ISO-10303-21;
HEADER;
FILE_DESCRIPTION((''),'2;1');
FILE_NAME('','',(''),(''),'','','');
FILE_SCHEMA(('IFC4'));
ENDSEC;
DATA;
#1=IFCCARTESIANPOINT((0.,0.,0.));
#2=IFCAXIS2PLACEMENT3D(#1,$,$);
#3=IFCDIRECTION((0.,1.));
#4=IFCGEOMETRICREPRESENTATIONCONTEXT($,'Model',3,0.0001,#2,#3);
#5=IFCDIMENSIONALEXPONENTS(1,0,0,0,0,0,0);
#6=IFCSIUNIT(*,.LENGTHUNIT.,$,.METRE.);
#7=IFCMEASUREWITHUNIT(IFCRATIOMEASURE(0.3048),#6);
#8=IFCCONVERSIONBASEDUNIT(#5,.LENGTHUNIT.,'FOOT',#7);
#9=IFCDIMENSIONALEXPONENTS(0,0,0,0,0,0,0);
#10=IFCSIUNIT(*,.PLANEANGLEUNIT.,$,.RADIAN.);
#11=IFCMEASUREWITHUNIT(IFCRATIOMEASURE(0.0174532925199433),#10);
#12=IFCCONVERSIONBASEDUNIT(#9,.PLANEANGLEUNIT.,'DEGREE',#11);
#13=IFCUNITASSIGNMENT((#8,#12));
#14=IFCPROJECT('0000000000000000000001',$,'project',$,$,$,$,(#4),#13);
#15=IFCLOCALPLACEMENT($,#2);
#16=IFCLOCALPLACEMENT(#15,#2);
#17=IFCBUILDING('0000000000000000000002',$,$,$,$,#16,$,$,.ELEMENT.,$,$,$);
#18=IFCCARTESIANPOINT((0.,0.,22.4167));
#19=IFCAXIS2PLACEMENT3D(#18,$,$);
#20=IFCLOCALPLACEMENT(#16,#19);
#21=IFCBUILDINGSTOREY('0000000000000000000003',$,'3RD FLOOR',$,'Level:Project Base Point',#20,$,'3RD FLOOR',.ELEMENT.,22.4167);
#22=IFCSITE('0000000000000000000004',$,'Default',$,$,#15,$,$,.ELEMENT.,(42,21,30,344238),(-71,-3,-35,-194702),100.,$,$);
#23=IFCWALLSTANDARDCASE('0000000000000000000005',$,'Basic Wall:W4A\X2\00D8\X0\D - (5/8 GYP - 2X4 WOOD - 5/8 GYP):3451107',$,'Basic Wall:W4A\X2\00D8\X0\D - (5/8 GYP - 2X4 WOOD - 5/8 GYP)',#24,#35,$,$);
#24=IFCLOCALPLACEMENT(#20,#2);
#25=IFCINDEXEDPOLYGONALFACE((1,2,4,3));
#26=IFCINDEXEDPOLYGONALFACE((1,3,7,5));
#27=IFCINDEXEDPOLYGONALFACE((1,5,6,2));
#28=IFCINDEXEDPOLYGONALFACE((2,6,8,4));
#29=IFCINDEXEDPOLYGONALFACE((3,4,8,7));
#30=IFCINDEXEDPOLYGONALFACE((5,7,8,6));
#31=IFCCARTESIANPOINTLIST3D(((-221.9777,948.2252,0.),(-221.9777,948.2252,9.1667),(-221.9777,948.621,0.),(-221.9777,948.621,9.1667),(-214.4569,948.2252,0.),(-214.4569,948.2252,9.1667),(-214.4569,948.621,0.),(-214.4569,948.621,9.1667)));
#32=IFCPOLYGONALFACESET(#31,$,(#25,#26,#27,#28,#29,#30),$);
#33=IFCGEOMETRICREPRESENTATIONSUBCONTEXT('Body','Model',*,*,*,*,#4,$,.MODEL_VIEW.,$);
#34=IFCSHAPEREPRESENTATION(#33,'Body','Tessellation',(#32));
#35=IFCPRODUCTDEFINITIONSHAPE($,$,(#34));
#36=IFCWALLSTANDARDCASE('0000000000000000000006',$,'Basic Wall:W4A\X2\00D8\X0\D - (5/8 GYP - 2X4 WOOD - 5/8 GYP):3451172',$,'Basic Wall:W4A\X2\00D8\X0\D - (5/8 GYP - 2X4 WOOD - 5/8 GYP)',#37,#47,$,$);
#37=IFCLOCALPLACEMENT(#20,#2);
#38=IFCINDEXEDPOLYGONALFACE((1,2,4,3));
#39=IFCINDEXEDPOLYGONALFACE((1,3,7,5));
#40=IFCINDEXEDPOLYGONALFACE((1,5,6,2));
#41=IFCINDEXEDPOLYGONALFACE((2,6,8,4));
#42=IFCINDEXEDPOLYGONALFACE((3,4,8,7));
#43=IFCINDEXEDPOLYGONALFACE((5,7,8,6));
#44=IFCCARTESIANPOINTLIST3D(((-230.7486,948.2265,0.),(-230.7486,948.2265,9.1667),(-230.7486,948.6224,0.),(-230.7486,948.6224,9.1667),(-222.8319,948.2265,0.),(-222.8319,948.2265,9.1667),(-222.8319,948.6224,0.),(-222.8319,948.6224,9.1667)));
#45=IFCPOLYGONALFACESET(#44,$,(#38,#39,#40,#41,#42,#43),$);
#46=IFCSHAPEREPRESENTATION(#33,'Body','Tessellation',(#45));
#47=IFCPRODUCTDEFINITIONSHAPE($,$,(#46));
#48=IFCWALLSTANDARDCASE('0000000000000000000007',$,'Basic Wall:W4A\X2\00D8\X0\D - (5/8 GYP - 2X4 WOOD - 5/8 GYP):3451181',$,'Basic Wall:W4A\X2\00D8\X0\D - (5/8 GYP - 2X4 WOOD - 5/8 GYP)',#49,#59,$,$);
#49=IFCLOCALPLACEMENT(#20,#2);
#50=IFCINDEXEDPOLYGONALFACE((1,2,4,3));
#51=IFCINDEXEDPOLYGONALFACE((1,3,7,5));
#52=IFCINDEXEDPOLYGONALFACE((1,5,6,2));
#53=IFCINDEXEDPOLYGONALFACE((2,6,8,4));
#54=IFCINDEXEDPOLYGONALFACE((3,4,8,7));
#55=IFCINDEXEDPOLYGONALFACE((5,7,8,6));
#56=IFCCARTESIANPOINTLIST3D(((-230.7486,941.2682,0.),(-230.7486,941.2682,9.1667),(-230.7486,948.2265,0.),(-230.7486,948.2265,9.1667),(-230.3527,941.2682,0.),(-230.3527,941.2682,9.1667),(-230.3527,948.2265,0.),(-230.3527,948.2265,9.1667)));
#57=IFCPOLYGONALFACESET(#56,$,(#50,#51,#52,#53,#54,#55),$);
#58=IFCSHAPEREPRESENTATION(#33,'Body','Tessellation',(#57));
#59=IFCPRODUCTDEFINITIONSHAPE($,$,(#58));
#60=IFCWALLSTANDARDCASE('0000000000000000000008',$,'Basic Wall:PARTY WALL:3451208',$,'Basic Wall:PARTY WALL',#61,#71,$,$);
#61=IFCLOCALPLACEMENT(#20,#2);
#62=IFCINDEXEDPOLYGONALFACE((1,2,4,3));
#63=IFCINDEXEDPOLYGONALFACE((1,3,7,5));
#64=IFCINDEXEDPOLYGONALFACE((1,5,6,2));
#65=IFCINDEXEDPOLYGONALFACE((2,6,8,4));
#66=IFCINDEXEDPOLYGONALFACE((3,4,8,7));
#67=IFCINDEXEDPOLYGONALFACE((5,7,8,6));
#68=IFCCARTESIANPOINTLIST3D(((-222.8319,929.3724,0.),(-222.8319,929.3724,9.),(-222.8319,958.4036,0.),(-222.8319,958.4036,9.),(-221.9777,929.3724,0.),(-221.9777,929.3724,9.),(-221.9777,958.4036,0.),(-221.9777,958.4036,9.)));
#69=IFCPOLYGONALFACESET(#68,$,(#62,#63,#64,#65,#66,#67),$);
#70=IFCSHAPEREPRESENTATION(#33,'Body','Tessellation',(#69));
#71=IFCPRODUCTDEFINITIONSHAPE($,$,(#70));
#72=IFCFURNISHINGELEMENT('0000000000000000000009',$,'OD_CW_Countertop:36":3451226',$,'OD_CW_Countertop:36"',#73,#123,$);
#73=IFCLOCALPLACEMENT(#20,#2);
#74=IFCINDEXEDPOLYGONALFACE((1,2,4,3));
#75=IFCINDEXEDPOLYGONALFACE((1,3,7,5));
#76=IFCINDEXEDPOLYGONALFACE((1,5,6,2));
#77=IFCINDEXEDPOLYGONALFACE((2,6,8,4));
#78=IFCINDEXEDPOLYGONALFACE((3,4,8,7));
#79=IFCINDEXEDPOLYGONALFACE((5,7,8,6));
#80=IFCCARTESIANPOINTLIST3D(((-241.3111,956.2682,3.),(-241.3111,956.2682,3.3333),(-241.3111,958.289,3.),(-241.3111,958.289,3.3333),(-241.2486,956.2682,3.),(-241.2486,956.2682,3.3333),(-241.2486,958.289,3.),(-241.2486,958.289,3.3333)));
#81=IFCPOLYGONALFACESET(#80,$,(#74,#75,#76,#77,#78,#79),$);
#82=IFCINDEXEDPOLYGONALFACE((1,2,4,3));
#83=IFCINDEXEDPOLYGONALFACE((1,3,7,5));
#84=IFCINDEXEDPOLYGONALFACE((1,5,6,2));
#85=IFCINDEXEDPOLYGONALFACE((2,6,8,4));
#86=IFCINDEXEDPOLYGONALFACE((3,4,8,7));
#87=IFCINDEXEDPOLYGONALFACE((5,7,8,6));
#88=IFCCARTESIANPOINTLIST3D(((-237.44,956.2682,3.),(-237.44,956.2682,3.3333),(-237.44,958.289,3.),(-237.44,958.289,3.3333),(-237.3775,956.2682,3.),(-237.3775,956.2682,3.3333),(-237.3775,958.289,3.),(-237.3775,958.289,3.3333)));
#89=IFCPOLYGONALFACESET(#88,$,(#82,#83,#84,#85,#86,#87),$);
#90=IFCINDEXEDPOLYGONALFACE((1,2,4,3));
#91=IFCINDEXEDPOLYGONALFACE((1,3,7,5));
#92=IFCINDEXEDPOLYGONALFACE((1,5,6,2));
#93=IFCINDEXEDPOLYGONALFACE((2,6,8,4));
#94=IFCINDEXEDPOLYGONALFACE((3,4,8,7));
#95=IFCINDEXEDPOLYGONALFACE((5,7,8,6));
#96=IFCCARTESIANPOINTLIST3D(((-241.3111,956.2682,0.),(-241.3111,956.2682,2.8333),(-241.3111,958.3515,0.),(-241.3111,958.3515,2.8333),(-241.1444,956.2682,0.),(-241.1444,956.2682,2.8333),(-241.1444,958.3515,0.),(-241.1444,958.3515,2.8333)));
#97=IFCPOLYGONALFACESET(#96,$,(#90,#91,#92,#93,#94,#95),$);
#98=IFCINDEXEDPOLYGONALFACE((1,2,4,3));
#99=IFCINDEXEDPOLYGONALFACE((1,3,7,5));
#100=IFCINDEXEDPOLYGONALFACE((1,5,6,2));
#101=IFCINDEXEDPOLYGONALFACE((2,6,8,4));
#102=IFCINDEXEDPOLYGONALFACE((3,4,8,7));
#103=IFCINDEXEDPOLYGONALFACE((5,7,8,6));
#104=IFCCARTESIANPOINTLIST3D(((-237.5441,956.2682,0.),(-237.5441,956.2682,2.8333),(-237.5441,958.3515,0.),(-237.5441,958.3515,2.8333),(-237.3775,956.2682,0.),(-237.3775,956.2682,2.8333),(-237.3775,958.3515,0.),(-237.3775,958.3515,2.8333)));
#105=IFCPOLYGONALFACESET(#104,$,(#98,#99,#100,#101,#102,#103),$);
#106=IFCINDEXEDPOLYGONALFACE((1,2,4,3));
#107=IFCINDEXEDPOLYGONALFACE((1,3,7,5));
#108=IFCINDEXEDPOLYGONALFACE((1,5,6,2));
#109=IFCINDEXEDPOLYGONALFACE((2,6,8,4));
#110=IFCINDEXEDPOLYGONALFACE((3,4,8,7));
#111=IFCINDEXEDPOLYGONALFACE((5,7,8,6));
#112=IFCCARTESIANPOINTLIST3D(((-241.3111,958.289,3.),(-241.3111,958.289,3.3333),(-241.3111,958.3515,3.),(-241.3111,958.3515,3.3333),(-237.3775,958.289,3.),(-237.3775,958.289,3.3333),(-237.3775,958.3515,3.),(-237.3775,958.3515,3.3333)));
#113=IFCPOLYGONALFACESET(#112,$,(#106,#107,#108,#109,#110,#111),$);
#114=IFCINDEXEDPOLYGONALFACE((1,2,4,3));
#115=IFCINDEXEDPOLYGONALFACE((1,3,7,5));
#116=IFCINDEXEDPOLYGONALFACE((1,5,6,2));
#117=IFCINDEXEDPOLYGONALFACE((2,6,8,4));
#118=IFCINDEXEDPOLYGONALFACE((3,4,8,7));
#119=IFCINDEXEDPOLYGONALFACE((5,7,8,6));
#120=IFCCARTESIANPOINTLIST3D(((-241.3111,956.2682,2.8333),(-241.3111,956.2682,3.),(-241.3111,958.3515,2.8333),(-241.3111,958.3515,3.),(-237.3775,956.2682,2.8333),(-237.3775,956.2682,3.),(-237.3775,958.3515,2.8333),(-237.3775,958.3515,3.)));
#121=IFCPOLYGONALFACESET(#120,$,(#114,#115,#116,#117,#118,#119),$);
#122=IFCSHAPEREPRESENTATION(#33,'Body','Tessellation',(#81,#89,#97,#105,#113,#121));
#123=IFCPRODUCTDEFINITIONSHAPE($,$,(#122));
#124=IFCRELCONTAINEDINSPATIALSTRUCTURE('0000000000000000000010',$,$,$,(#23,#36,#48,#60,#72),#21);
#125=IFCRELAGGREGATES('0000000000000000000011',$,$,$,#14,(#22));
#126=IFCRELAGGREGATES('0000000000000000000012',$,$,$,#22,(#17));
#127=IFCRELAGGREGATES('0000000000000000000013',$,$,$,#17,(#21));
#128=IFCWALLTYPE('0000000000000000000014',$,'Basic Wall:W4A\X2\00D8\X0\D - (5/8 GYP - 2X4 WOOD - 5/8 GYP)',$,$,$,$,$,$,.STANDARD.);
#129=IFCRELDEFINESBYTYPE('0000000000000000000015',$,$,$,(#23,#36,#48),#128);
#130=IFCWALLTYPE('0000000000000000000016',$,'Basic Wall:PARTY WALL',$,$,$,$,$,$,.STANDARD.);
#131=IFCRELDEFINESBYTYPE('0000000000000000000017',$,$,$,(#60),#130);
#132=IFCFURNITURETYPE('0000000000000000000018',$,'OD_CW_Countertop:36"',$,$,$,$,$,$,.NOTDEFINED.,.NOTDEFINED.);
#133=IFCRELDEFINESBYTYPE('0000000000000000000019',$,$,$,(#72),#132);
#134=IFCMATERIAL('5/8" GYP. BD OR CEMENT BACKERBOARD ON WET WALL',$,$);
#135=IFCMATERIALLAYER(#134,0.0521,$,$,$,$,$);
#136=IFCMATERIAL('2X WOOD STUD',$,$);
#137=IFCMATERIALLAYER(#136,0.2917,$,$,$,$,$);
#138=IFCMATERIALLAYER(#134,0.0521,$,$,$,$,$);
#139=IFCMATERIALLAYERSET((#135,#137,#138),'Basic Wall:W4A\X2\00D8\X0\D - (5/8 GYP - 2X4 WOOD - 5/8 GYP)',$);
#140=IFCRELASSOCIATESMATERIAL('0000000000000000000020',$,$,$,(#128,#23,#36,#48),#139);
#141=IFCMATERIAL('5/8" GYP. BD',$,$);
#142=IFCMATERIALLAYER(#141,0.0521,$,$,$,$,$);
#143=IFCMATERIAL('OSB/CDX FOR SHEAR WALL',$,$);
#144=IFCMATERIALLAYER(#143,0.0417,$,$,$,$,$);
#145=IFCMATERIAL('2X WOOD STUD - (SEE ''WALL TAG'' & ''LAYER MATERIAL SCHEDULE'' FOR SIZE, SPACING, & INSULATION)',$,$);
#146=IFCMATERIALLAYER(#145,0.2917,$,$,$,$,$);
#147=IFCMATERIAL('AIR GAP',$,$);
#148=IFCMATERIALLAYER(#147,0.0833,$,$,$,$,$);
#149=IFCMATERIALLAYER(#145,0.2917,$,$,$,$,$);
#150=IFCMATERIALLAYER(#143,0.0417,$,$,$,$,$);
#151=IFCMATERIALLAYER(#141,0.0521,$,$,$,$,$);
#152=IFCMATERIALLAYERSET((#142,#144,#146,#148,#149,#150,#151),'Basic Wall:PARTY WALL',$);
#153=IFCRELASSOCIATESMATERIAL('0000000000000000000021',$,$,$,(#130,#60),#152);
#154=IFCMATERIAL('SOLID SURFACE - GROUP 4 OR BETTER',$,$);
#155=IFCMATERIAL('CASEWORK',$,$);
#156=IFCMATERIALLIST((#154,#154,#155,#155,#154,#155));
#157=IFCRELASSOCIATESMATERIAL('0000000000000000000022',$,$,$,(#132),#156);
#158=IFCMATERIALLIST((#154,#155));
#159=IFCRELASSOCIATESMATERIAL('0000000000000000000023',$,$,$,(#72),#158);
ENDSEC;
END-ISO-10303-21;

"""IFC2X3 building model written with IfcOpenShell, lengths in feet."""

from ifc_helpers import new_model, entity, si_unit, converted_unit, direction, frame, frame_2d, origin, origin_2d_with_axis, place, context, subcontext, project, spatial, rectangle, extrude, source, transform, mapped, material, material_list, layer, layer_set, layer_usage, type_object, type_shapes, element, save


model = new_model("IFC2X3")

# Units and contexts
model_context = context("Model", 3, precision=0.0001, world=origin(), true_north=direction((0.0, 1.0)))
body_context = subcontext(model_context, "Body", "Model", "MODEL_VIEW")
ifc_project = project(units=[converted_unit("LENGTHUNIT", "FOOT", entity("IfcRatioMeasure", 0.3048), si_unit("LENGTHUNIT", "METRE"), dimensions=[1, 0, 0, 0, 0, 0, 0]), converted_unit("PLANEANGLEUNIT", "DEGREE", entity("IfcRatioMeasure", 0.0174532925199433), si_unit("PLANEANGLEUNIT", "RADIAN"), dimensions=[0, 0, 0, 0, 0, 0, 0])], contexts=[model_context])

# Site, building, storey
site_placement = place(None, origin())
site = spatial("IfcSite", under=ifc_project, at=site_placement, Name="Default", CompositionType="ELEMENT", RefLatitude=(42, 21, 30, 344238), RefLongitude=(-71, -3, -35, -194702), RefElevation=100.0)
building_placement = place(site_placement, origin())
building = spatial("IfcBuilding", under=site, at=building_placement, CompositionType="ELEMENT")
storey_placement = place(building_placement, frame((0.0, 0.0, 22.4167)))
storey = spatial("IfcBuildingStorey", under=building, at=storey_placement, Name="3RD FLOOR", ObjectType="Level:Project Base Point", LongName="3RD FLOOR", CompositionType="ELEMENT", Elevation=22.4167)

# Walls
ifc_material_1 = material(Name="5/8\" GYP. BD OR CEMENT BACKERBOARD ON WET WALL")
ifc_layer_1 = layer(ifc_material_1, 0.0521)
ifc_material_2 = material(Name="2X WOOD STUD")
ifc_layer_2 = layer(ifc_material_2, 0.2917)
ifc_layer_3 = layer(ifc_material_1, 0.0521)
ifc_layer_set_1 = layer_set([ifc_layer_1, ifc_layer_2, ifc_layer_3], Name="Basic Wall:W4AØD - (5/8 GYP - 2X4 WOOD - 5/8 GYP)")
ifc_layer_usage_1 = layer_usage(ifc_layer_set_1, "AXIS2", "POSITIVE", -0.1979)
wall_type_1 = type_object("IfcWallType", Name="Basic Wall:W4AØD - (5/8 GYP - 2X4 WOOD - 5/8 GYP)", PredefinedType="STANDARD", material=ifc_layer_set_1)
wall_1_placement = place(storey_placement, frame((-221.9777, 948.4231, 0.0)))
element("IfcWallStandardCase", 1, at=wall_1_placement, inside=storey, type_object=wall_type_1, material=ifc_layer_usage_1, Name="Basic Wall:W4AØD - (5/8 GYP - 2X4 WOOD - 5/8 GYP):3451107", ObjectType="Basic Wall:W4AØD - (5/8 GYP - 2X4 WOOD - 5/8 GYP)", context=body_context, shape_type="SweptSolid", body=[
    extrude(rectangle(XDim=7.5208, YDim=0.3958, at=frame_2d((3.7604, 0.0), x_axis=(-1.0, 0.0))), origin(), (0.0, 0.0, 1.0), 9.1667),
])
ifc_layer_usage_2 = layer_usage(ifc_layer_set_1, "AXIS2", "NEGATIVE", 0.1979)
wall_2_placement = place(storey_placement, frame((-222.8319, 948.4244, 0.0), z_axis=(0.0, 0.0, 1.0), x_axis=(-1.0, 0.0, 0.0)))
element("IfcWallStandardCase", 2, at=wall_2_placement, inside=storey, type_object=wall_type_1, material=ifc_layer_usage_2, Name="Basic Wall:W4AØD - (5/8 GYP - 2X4 WOOD - 5/8 GYP):3451172", ObjectType="Basic Wall:W4AØD - (5/8 GYP - 2X4 WOOD - 5/8 GYP)", context=body_context, shape_type="SweptSolid", body=[
    extrude(rectangle(XDim=7.9167, YDim=0.3958, at=frame_2d((3.9583, 0.0), x_axis=(-1.0, 0.0))), origin(), (0.0, 0.0, 1.0), 9.1667),
])

# Wall
ifc_layer_usage_3 = layer_usage(ifc_layer_set_1, "AXIS2", "NEGATIVE", 0.1979)
wall_3_placement = place(storey_placement, frame((-230.5507, 941.2682, 0.0), z_axis=(0.0, 0.0, 1.0), x_axis=(0.0, 1.0, 0.0)))
element("IfcWallStandardCase", 3, at=wall_3_placement, inside=storey, type_object=wall_type_1, material=ifc_layer_usage_3, Name="Basic Wall:W4AØD - (5/8 GYP - 2X4 WOOD - 5/8 GYP):3451181", ObjectType="Basic Wall:W4AØD - (5/8 GYP - 2X4 WOOD - 5/8 GYP)", context=body_context, shape_type="SweptSolid", body=[
    extrude(rectangle(XDim=6.9583, YDim=0.3958, at=frame_2d((3.4792, 0.0), x_axis=(-1.0, 0.0))), origin(), (0.0, 0.0, 1.0), 9.1667),
])

# Wall
ifc_material_3 = material(Name="5/8\" GYP. BD")
ifc_layer_4 = layer(ifc_material_3, 0.0521)
ifc_material_4 = material(Name="OSB/CDX FOR SHEAR WALL")
ifc_layer_5 = layer(ifc_material_4, 0.0417)
ifc_material_5 = material(Name="2X WOOD STUD - (SEE 'WALL TAG' & 'LAYER MATERIAL SCHEDULE' FOR SIZE, SPACING, & INSULATION)")
ifc_layer_6 = layer(ifc_material_5, 0.2917)
ifc_material_6 = material(Name="AIR GAP")
ifc_layer_7 = layer(ifc_material_6, 0.0833)
ifc_layer_8 = layer(ifc_material_5, 0.2917)
ifc_layer_9 = layer(ifc_material_4, 0.0417)
ifc_layer_10 = layer(ifc_material_3, 0.0521)
ifc_layer_set_2 = layer_set([ifc_layer_4, ifc_layer_5, ifc_layer_6, ifc_layer_7, ifc_layer_8, ifc_layer_9, ifc_layer_10], Name="Basic Wall:PARTY WALL")
ifc_layer_usage_4 = layer_usage(ifc_layer_set_2, "AXIS2", "NEGATIVE", 0.4271)
wall_type_2 = type_object("IfcWallType", Name="Basic Wall:PARTY WALL", PredefinedType="STANDARD", material=ifc_layer_set_2)
wall_4_placement = place(storey_placement, frame((-222.4048, 929.3724, 0.0), z_axis=(0.0, 0.0, 1.0), x_axis=(0.0, 1.0, 0.0)))
element("IfcWallStandardCase", 4, at=wall_4_placement, inside=storey, type_object=wall_type_2, material=ifc_layer_usage_4, Name="Basic Wall:PARTY WALL:3451208", ObjectType="Basic Wall:PARTY WALL", context=body_context, shape_type="SweptSolid", body=[
    extrude(rectangle(XDim=29.0313, YDim=0.8542, at=frame_2d((14.5156, 0.0), x_axis=(-1.0, 0.0))), origin(), (0.0, 0.0, 1.0), 9.0),
])

# Furnishing element
ifc_material_7 = material(Name="CASEWORK")
ifc_material_8 = material(Name="SOLID SURFACE - GROUP 4 OR BETTER")
ifc_material_list_1 = material_list([ifc_material_8, ifc_material_7])
ifc_material_list_2 = material_list([ifc_material_8, ifc_material_8, ifc_material_7, ifc_material_7, ifc_material_8, ifc_material_7])
furniture_type_1 = type_object("IfcFurnitureType", Name="OD_CW_Countertop:36\"", material=ifc_material_list_2)
shared_shape_1 = source(origin(), body_context, "Body", "SweptSolid", [
    extrude(rectangle(XDim=2.0208, YDim=0.0625, at=origin_2d_with_axis()), frame((3.9024, 1.0729, 3.0), z_axis=(0.0, 0.0, 1.0), x_axis=(0.0, 1.0, 0.0)), (0.0, 0.0, 1.0), 0.3333),
    extrude(rectangle(XDim=2.0208, YDim=0.0625, at=origin_2d_with_axis()), frame((0.0313, 1.0729, 3.0), z_axis=(0.0, 0.0, 1.0), x_axis=(0.0, 1.0, 0.0)), (0.0, 0.0, 1.0), 0.3333),
    extrude(rectangle(XDim=0.1667, YDim=2.0833, at=frame_2d((0.0, 0.0), x_axis=(1.0, 0.0))), frame((3.8503, 1.0417, 0.0)), (0.0, 0.0, 1.0), 2.8333),
    extrude(rectangle(XDim=0.1667, YDim=2.0833, at=frame_2d((0.0, 0.0), x_axis=(1.0, 0.0))), frame((0.0833, 1.0417, 0.0)), (0.0, 0.0, 1.0), 2.8333),
    extrude(rectangle(XDim=3.9336, YDim=0.0625, at=frame_2d((0.0, 0.0), x_axis=(1.0, 0.0))), frame((1.9668, 0.0313, 3.0)), (0.0, 0.0, 1.0), 0.3333),
    extrude(rectangle(XDim=3.9336, YDim=2.0833, at=origin_2d_with_axis()), frame((1.9668, 1.0417, 2.8333)), (0.0, 0.0, 1.0), 0.1667),
])
type_shapes(furniture_type_1, [shared_shape_1])
furnishing_1_placement = place(storey_placement, frame((-237.3775, 958.3515, 0.0), z_axis=(0.0, 0.0, 1.0), x_axis=(-1.0, 0.0, 0.0)))
element("IfcFurnishingElement", 5, at=furnishing_1_placement, inside=storey, type_object=furniture_type_1, material=ifc_material_list_1, Name="OD_CW_Countertop:36\":3451226", ObjectType="OD_CW_Countertop:36\"", context=body_context, shape_type="MappedRepresentation", body=[
    mapped(shared_shape_1, transform((0.0, 0.0, 0.0), scale=1.0)),
])

save(model, "model.ifc")
